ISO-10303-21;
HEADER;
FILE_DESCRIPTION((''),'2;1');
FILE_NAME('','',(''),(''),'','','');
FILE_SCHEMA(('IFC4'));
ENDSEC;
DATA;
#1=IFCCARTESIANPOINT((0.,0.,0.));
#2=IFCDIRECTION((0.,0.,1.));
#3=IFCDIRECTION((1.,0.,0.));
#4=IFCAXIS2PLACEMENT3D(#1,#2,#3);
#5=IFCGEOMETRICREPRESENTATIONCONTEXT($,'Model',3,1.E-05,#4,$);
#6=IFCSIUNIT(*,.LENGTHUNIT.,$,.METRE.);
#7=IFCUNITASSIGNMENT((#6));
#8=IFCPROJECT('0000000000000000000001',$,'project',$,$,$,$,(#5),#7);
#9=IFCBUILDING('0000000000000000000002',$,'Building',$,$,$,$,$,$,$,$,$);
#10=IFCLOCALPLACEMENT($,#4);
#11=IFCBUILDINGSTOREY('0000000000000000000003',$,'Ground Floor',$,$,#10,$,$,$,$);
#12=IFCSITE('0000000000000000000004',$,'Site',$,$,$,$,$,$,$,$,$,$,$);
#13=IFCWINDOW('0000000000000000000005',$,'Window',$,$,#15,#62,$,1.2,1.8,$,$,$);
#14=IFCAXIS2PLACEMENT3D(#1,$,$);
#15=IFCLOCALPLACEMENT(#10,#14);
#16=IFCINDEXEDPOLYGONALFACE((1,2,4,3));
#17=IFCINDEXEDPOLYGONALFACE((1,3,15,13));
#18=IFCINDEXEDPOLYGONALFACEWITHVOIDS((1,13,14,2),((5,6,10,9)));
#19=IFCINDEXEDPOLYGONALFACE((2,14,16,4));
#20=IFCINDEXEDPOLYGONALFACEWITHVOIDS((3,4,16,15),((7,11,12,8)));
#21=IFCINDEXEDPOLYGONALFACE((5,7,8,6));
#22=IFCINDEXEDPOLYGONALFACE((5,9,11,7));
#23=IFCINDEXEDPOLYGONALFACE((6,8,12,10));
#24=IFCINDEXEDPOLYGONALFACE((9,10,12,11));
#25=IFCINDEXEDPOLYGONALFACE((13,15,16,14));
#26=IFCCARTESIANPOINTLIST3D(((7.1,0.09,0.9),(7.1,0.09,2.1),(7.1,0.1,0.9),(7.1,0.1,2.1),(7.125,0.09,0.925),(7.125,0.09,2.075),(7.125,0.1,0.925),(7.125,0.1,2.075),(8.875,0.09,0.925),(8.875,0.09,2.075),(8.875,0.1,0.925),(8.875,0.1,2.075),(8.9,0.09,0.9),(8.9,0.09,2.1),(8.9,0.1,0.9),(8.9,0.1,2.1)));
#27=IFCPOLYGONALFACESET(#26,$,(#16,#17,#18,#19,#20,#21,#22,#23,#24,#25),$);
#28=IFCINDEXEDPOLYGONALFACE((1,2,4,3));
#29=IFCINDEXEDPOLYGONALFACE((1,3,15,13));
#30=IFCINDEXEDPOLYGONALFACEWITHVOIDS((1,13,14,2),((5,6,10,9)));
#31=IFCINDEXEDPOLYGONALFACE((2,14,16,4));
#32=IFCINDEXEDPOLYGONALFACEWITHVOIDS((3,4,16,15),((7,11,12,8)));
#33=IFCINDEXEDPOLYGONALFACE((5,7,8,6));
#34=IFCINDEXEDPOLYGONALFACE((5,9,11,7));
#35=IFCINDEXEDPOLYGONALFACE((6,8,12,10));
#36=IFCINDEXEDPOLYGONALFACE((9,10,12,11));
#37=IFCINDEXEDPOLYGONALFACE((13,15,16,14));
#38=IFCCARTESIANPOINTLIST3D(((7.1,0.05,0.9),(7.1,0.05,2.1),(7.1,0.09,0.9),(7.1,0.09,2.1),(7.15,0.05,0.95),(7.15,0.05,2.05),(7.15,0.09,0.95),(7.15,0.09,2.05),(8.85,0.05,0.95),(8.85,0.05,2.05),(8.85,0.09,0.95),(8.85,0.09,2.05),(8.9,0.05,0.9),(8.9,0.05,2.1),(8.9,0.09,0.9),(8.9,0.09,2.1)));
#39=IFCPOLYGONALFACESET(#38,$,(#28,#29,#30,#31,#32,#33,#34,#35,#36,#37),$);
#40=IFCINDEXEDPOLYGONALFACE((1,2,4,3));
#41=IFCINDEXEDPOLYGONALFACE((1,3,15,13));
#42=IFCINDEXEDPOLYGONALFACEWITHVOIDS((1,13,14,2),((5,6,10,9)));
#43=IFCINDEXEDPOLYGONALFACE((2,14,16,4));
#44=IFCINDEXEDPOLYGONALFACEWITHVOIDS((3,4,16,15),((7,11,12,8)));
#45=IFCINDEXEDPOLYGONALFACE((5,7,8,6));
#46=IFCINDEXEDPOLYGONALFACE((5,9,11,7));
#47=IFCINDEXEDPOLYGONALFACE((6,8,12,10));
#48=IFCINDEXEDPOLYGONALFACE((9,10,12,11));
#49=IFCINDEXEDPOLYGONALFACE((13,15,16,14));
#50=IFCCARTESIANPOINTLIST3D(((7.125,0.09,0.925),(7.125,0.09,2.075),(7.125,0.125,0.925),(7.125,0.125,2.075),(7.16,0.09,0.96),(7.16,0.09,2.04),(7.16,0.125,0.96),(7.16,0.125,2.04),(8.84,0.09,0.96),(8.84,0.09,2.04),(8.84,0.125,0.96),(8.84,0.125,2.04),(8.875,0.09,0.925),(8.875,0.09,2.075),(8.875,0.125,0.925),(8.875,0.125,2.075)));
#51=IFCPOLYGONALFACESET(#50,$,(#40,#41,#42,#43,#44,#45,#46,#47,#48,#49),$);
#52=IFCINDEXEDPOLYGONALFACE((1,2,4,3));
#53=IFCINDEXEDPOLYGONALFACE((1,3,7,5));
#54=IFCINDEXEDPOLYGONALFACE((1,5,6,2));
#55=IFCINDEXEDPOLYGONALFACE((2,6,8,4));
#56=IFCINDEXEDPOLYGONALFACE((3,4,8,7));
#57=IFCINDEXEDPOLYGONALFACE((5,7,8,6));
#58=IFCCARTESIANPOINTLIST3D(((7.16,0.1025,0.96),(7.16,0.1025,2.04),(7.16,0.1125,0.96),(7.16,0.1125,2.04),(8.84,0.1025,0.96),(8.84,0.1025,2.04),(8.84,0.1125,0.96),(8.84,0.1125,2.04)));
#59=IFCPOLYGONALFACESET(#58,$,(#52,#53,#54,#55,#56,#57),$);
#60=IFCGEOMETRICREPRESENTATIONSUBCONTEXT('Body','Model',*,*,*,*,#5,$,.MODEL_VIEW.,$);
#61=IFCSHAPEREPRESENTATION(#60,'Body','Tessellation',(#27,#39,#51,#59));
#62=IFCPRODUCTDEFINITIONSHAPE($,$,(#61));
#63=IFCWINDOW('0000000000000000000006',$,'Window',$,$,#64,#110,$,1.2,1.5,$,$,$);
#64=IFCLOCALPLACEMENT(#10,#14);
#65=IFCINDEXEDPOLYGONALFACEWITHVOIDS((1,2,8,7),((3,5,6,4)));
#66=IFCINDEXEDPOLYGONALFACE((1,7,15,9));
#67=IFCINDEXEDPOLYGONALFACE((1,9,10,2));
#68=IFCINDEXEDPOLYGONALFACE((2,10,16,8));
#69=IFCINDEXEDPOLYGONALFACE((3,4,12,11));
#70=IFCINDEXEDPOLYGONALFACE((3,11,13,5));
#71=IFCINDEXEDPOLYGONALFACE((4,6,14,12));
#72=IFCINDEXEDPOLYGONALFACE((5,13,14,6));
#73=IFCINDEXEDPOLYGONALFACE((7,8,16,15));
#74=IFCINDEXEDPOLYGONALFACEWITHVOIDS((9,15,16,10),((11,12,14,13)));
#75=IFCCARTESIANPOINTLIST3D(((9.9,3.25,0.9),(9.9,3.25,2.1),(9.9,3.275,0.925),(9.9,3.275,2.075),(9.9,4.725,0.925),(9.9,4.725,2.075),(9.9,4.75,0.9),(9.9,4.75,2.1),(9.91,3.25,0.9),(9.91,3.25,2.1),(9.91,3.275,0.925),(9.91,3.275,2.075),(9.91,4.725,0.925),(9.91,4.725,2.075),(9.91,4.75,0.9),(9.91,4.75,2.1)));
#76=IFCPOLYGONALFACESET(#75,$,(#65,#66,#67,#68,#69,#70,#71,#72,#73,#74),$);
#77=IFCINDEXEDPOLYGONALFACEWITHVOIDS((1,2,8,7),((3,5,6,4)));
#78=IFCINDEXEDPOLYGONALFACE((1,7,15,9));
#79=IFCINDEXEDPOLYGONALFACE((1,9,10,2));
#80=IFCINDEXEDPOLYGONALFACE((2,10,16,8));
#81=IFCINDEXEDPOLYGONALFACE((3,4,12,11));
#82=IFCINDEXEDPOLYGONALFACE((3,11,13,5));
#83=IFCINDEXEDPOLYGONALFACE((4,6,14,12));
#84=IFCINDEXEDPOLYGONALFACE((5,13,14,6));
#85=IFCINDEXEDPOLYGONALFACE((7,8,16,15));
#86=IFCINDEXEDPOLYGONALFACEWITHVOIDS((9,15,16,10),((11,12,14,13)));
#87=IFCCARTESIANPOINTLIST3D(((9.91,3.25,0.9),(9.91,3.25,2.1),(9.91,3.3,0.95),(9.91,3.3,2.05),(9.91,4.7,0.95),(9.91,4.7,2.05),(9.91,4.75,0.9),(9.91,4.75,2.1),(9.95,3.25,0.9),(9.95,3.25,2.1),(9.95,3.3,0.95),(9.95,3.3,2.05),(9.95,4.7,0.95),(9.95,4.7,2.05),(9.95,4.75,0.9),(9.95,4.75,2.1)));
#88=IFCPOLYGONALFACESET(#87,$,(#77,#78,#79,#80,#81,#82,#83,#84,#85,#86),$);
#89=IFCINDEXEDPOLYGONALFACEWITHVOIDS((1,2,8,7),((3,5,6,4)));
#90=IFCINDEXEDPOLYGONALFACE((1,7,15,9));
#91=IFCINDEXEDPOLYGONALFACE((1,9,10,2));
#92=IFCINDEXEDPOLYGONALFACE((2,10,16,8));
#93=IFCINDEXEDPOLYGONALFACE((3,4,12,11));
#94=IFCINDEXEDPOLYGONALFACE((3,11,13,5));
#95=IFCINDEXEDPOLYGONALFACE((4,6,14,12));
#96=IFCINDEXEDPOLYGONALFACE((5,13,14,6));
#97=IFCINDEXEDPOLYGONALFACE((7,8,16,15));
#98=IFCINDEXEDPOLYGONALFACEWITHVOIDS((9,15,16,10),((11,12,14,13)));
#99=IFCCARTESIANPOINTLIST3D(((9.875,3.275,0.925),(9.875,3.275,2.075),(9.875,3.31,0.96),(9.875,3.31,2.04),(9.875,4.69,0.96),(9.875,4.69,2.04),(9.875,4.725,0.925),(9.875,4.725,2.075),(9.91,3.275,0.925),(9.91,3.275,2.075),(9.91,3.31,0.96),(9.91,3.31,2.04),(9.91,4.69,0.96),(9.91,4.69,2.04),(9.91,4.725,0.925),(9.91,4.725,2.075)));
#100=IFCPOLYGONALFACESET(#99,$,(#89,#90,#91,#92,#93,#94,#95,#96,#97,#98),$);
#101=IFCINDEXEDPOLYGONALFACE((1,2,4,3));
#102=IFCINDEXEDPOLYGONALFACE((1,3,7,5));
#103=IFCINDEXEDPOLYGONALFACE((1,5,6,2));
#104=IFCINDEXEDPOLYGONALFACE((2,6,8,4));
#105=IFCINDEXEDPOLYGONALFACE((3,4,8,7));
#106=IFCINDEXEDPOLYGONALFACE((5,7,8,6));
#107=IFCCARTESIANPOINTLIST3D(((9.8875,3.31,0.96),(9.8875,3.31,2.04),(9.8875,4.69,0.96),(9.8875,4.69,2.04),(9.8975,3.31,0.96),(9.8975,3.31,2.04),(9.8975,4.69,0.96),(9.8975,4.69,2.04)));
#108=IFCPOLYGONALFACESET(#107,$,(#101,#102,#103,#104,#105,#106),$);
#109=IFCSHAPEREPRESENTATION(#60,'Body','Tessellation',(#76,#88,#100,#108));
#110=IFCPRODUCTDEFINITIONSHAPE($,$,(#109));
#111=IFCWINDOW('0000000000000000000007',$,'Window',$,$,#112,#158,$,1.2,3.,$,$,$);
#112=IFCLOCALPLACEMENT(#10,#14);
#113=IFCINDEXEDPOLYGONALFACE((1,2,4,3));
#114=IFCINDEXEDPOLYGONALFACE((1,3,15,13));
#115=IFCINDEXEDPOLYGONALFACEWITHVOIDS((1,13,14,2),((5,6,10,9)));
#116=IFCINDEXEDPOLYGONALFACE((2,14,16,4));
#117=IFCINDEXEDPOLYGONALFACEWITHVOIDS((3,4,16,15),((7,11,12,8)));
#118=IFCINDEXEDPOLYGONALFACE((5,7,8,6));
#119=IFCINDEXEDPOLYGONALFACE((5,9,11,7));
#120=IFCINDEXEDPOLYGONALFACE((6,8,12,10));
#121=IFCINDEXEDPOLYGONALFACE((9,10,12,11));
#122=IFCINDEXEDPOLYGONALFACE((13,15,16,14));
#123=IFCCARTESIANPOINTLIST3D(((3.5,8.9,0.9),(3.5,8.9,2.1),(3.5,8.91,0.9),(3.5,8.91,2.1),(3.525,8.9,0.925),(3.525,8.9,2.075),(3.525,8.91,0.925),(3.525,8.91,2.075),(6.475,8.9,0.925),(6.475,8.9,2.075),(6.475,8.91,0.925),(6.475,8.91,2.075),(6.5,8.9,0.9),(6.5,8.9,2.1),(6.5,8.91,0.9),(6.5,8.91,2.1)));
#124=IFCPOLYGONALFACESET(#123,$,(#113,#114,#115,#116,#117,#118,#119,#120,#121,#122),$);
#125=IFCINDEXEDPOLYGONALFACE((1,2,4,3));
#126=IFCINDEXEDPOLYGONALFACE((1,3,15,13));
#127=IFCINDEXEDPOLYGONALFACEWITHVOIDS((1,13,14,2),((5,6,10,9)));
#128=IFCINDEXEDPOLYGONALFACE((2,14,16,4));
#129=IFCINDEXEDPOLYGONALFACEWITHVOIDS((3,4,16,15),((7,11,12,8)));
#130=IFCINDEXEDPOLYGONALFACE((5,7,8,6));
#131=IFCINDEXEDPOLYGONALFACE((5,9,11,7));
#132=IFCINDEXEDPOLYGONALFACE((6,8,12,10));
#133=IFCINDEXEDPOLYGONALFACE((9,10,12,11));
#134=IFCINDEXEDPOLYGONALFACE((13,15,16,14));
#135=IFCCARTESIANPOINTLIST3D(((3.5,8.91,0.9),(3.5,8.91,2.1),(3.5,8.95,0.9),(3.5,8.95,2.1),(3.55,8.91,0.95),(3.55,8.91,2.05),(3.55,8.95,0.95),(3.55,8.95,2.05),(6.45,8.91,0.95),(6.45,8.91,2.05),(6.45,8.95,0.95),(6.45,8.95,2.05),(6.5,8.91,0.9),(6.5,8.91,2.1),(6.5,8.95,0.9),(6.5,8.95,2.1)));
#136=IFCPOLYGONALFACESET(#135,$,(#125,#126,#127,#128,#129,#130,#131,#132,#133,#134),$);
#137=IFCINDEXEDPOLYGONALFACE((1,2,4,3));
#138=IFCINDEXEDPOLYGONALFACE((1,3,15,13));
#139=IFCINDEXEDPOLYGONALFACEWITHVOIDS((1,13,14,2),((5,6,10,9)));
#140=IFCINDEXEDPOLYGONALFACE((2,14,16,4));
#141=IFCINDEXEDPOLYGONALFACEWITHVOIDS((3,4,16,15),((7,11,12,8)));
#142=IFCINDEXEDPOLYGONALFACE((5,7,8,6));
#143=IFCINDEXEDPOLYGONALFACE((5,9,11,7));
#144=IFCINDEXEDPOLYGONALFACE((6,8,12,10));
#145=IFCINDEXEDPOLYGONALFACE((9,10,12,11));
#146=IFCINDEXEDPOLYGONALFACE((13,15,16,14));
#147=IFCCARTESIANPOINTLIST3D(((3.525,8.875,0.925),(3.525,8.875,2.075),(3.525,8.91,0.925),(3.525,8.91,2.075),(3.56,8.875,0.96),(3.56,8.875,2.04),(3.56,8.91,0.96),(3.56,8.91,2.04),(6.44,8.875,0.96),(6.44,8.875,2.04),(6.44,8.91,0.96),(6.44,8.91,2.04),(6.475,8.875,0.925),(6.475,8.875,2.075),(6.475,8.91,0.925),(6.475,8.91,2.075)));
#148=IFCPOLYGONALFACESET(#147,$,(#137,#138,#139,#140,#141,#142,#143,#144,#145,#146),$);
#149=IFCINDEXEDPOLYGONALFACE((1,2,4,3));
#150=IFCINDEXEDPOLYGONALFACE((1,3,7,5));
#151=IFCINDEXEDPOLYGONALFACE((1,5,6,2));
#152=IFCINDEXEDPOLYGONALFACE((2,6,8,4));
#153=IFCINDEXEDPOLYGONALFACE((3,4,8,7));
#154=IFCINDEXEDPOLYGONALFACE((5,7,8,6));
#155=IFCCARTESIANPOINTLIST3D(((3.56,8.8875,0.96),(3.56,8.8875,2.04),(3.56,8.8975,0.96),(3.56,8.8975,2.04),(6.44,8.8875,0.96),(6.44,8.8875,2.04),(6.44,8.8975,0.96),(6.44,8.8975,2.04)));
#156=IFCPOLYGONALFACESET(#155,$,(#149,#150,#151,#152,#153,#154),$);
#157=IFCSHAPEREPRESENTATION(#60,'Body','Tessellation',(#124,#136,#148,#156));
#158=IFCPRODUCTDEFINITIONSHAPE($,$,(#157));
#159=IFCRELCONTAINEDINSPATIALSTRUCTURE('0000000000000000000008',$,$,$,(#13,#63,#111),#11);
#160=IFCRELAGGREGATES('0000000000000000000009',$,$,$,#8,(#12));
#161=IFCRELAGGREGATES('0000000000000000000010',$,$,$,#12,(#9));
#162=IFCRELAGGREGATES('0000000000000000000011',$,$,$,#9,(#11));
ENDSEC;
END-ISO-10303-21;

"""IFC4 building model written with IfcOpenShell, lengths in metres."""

from ifc_helpers import new_model, si_unit, frame, origin_with_axes, place, context, subcontext, project, spatial, line, indexed_curve, outline, extrude, element, save


model = new_model("IFC4")

# Units and contexts
model_context = context("Model", 3, precision=1e-05, world=origin_with_axes())
body_context = subcontext(model_context, "Body", "Model", "MODEL_VIEW")
ifc_project = project(units=[si_unit("LENGTHUNIT", "METRE")], contexts=[model_context])

# Site, building, storey
site = spatial("IfcSite", under=ifc_project, Name="Site")
building = spatial("IfcBuilding", under=site, Name="Building")
storey_placement = place(None, origin_with_axes())
storey = spatial("IfcBuildingStorey", under=building, at=storey_placement, Name="Ground Floor")

# Windows
window_1_placement = place(storey_placement, frame((7.1, 0.0, 0.9), z_axis=(0.0, 0.0, 1.0), x_axis=(1.0, 0.0, 0.0)))
element("IfcWindow", 1, at=window_1_placement, inside=storey, Name="Window", OverallHeight=1.2, OverallWidth=1.8, context=body_context, shape_type="SweptSolid", body=[
    extrude(outline(indexed_curve([(0.0, 0.0), (1.8, 0.0), (1.8, 1.2), (0.0, 1.2)], segments=[line(1, 2, 3, 4, 1)]), holes=[indexed_curve([(0.025, 0.025), (1.775, 0.025), (1.775, 1.175), (0.025, 1.175)], segments=[line(1, 2, 3, 4, 1)])]), frame((0.0, 0.09, 0.0), z_axis=(0.0, -1.0, 0.0), x_axis=(1.0, 0.0, 0.0)), (0.0, 0.0, -1.0), 0.01),
    extrude(outline(indexed_curve([(0.0, 0.0), (1.8, 0.0), (1.8, 1.2), (0.0, 1.2)], segments=[line(1, 2, 3, 4, 1)]), holes=[indexed_curve([(0.05, 0.05), (1.75, 0.05), (1.75, 1.15), (0.05, 1.15)], segments=[line(1, 2, 3, 4, 1)])]), frame((0.0, 0.05, 0.0), z_axis=(0.0, -1.0, 0.0), x_axis=(1.0, 0.0, 0.0)), (0.0, 0.0, -1.0), 0.04),
    extrude(outline(indexed_curve([(0.0, 0.0), (1.75, 0.0), (1.75, 1.15), (0.0, 1.15)], segments=[line(1, 2, 3, 4, 1)]), holes=[indexed_curve([(0.035, 0.035), (1.715, 0.035), (1.715, 1.115), (0.035, 1.115)], segments=[line(1, 2, 3, 4, 1)])]), frame((0.025, 0.09, 0.025), z_axis=(0.0, -1.0, 0.0), x_axis=(1.0, 0.0, 0.0)), (0.0, 0.0, -1.0), 0.035),
    extrude(outline(indexed_curve([(0.035, 0.035), (1.715, 0.035), (1.715, 1.115), (0.035, 1.115)], segments=[line(1, 2, 3, 4, 1)])), frame((0.025, 0.1025, 0.025), z_axis=(0.0, -1.0, 0.0), x_axis=(1.0, 0.0, 0.0)), (0.0, 0.0, -1.0), 0.01),
])
window_2_placement = place(storey_placement, frame((10.0, 3.25, 0.9), z_axis=(0.0, 0.0, 1.0), x_axis=(0.0, 1.0, 0.0)))
element("IfcWindow", 2, at=window_2_placement, inside=storey, Name="Window", OverallHeight=1.2, OverallWidth=1.5, context=body_context, shape_type="SweptSolid", body=[
    extrude(outline(indexed_curve([(0.0, 0.0), (1.5, 0.0), (1.5, 1.2), (0.0, 1.2)], segments=[line(1, 2, 3, 4, 1)]), holes=[indexed_curve([(0.025, 0.025), (1.475, 0.025), (1.475, 1.175), (0.025, 1.175)], segments=[line(1, 2, 3, 4, 1)])]), frame((0.0, 0.09, 0.0), z_axis=(0.0, -1.0, 0.0), x_axis=(1.0, 0.0, 0.0)), (0.0, 0.0, -1.0), 0.01),
    extrude(outline(indexed_curve([(0.0, 0.0), (1.5, 0.0), (1.5, 1.2), (0.0, 1.2)], segments=[line(1, 2, 3, 4, 1)]), holes=[indexed_curve([(0.05, 0.05), (1.45, 0.05), (1.45, 1.15), (0.05, 1.15)], segments=[line(1, 2, 3, 4, 1)])]), frame((0.0, 0.05, 0.0), z_axis=(0.0, -1.0, 0.0), x_axis=(1.0, 0.0, 0.0)), (0.0, 0.0, -1.0), 0.04),
    extrude(outline(indexed_curve([(0.0, 0.0), (1.45, 0.0), (1.45, 1.15), (0.0, 1.15)], segments=[line(1, 2, 3, 4, 1)]), holes=[indexed_curve([(0.035, 0.035), (1.415, 0.035), (1.415, 1.115), (0.035, 1.115)], segments=[line(1, 2, 3, 4, 1)])]), frame((0.025, 0.09, 0.025), z_axis=(0.0, -1.0, 0.0), x_axis=(1.0, 0.0, 0.0)), (0.0, 0.0, -1.0), 0.035),
    extrude(outline(indexed_curve([(0.035, 0.035), (1.415, 0.035), (1.415, 1.115), (0.035, 1.115)], segments=[line(1, 2, 3, 4, 1)])), frame((0.025, 0.1025, 0.025), z_axis=(0.0, -1.0, 0.0), x_axis=(1.0, 0.0, 0.0)), (0.0, 0.0, -1.0), 0.01),
])
window_3_placement = place(storey_placement, frame((6.5, 9.0, 0.9), z_axis=(0.0, 0.0, 1.0), x_axis=(-1.0, 0.0, 0.0)))
element("IfcWindow", 3, at=window_3_placement, inside=storey, Name="Window", OverallHeight=1.2, OverallWidth=3.0, context=body_context, shape_type="SweptSolid", body=[
    extrude(outline(indexed_curve([(0.0, 0.0), (3.0, 0.0), (3.0, 1.2), (0.0, 1.2)], segments=[line(1, 2, 3, 4, 1)]), holes=[indexed_curve([(0.025, 0.025), (2.975, 0.025), (2.975, 1.175), (0.025, 1.175)], segments=[line(1, 2, 3, 4, 1)])]), frame((0.0, 0.09, 0.0), z_axis=(0.0, -1.0, 0.0), x_axis=(1.0, 0.0, 0.0)), (0.0, 0.0, -1.0), 0.01),
    extrude(outline(indexed_curve([(0.0, 0.0), (3.0, 0.0), (3.0, 1.2), (0.0, 1.2)], segments=[line(1, 2, 3, 4, 1)]), holes=[indexed_curve([(0.05, 0.05), (2.95, 0.05), (2.95, 1.15), (0.05, 1.15)], segments=[line(1, 2, 3, 4, 1)])]), frame((0.0, 0.05, 0.0), z_axis=(0.0, -1.0, 0.0), x_axis=(1.0, 0.0, 0.0)), (0.0, 0.0, -1.0), 0.04),
    extrude(outline(indexed_curve([(0.0, 0.0), (2.95, 0.0), (2.95, 1.15), (0.0, 1.15)], segments=[line(1, 2, 3, 4, 1)]), holes=[indexed_curve([(0.035, 0.035), (2.915, 0.035), (2.915, 1.115), (0.035, 1.115)], segments=[line(1, 2, 3, 4, 1)])]), frame((0.025, 0.09, 0.025), z_axis=(0.0, -1.0, 0.0), x_axis=(1.0, 0.0, 0.0)), (0.0, 0.0, -1.0), 0.035),
    extrude(outline(indexed_curve([(0.035, 0.035), (2.915, 0.035), (2.915, 1.115), (0.035, 1.115)], segments=[line(1, 2, 3, 4, 1)])), frame((0.025, 0.1025, 0.025), z_axis=(0.0, -1.0, 0.0), x_axis=(1.0, 0.0, 0.0)), (0.0, 0.0, -1.0), 0.01),
])

save(model, "model.ifc")
